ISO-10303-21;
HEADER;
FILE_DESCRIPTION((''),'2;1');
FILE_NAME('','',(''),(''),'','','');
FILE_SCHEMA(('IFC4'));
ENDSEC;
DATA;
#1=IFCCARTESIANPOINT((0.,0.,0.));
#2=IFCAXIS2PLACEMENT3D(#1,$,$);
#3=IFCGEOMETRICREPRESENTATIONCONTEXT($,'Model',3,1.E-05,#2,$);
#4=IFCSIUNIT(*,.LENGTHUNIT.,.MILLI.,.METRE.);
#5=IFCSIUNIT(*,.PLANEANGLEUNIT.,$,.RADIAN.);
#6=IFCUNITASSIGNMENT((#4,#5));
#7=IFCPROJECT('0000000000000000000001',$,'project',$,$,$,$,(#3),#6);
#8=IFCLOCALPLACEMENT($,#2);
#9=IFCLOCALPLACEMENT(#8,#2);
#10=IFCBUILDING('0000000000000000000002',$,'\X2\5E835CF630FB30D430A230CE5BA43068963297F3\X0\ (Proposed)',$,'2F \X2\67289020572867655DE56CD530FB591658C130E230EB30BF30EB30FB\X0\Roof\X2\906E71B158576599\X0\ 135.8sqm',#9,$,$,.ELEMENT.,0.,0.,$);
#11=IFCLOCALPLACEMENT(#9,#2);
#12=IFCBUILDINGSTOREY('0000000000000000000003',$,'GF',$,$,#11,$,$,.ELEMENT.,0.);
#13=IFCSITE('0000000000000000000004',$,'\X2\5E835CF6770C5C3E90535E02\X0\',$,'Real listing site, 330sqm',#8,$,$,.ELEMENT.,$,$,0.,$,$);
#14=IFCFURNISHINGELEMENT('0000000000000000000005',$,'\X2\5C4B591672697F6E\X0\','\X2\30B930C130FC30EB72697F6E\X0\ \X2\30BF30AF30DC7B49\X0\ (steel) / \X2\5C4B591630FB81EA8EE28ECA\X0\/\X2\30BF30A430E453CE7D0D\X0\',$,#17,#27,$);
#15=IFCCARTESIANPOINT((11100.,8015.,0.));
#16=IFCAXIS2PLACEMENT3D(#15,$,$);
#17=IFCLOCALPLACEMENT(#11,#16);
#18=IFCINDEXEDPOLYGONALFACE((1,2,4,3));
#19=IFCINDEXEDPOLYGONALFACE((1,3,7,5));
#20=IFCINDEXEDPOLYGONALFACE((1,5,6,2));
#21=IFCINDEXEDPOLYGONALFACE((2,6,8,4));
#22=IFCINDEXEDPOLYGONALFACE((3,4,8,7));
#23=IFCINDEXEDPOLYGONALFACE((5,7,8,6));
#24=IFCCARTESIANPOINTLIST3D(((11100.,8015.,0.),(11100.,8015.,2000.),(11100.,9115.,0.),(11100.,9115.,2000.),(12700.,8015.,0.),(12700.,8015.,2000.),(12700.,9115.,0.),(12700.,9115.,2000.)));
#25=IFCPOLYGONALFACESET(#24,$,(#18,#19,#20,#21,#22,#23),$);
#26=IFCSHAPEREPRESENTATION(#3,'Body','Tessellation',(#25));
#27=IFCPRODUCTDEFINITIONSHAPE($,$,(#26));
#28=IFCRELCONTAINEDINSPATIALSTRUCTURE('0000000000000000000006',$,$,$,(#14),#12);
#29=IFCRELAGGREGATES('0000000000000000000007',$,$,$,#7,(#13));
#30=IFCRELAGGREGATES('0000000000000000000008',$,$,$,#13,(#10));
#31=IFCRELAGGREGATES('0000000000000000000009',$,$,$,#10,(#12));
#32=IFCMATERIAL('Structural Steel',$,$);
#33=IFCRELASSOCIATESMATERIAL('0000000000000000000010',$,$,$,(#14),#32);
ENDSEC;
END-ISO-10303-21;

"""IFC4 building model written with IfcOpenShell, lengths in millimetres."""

from ifc_helpers import new_model, si_unit, frame, frame_2d, origin, place, context, project, spatial, rectangle, extrude, material, element, save


model = new_model("IFC4")

# Units and contexts
model_context = context("Model", 3, precision=1e-05, world=origin())
ifc_project = project(units=[si_unit("LENGTHUNIT", "METRE", prefix="MILLI"), si_unit("PLANEANGLEUNIT", "RADIAN")], contexts=[model_context])

# Site, building, storey
site_placement = place(None, origin())
site = spatial("IfcSite", under=ifc_project, at=site_placement, Name="広島県尾道市", ObjectType="Real listing site, 330sqm", CompositionType="ELEMENT", RefElevation=0.0)
building_placement = place(site_placement, origin())
building = spatial("IfcBuilding", under=site, at=building_placement, Name="広島・ピアノ室と防音 (Proposed)", ObjectType="2F 木造在来工法・外壁モルタル・Roof遮熱塗料 135.8sqm", CompositionType="ELEMENT", ElevationOfRefHeight=0.0, ElevationOfTerrain=0.0)
storey_placement = place(building_placement, origin())
storey = spatial("IfcBuildingStorey", under=building, at=storey_placement, Name="GF", CompositionType="ELEMENT", Elevation=0.0)

# Shared definitions
ifc_material_1 = material(Name="Structural Steel")

# Furnishing element
furnishing_1_placement = place(storey_placement, frame((11100.0, 8015.0, 0.0)))
element("IfcFurnishingElement", 1, at=furnishing_1_placement, inside=storey, material=ifc_material_1, Name="屋外物置", Description="スチール物置 タクボ等 (steel) / 屋外・自転車/タイヤ収納", context=model_context, shape_type="SweptSolid", body=[
    extrude(rectangle(XDim=1600.0, YDim=1100.0, at=frame_2d((800.0, 550.0))), frame((11100.0, 8015.0, 0.0)), (0.0, 0.0, 1.0), 2000.0),
])

save(model, "model.ifc")
